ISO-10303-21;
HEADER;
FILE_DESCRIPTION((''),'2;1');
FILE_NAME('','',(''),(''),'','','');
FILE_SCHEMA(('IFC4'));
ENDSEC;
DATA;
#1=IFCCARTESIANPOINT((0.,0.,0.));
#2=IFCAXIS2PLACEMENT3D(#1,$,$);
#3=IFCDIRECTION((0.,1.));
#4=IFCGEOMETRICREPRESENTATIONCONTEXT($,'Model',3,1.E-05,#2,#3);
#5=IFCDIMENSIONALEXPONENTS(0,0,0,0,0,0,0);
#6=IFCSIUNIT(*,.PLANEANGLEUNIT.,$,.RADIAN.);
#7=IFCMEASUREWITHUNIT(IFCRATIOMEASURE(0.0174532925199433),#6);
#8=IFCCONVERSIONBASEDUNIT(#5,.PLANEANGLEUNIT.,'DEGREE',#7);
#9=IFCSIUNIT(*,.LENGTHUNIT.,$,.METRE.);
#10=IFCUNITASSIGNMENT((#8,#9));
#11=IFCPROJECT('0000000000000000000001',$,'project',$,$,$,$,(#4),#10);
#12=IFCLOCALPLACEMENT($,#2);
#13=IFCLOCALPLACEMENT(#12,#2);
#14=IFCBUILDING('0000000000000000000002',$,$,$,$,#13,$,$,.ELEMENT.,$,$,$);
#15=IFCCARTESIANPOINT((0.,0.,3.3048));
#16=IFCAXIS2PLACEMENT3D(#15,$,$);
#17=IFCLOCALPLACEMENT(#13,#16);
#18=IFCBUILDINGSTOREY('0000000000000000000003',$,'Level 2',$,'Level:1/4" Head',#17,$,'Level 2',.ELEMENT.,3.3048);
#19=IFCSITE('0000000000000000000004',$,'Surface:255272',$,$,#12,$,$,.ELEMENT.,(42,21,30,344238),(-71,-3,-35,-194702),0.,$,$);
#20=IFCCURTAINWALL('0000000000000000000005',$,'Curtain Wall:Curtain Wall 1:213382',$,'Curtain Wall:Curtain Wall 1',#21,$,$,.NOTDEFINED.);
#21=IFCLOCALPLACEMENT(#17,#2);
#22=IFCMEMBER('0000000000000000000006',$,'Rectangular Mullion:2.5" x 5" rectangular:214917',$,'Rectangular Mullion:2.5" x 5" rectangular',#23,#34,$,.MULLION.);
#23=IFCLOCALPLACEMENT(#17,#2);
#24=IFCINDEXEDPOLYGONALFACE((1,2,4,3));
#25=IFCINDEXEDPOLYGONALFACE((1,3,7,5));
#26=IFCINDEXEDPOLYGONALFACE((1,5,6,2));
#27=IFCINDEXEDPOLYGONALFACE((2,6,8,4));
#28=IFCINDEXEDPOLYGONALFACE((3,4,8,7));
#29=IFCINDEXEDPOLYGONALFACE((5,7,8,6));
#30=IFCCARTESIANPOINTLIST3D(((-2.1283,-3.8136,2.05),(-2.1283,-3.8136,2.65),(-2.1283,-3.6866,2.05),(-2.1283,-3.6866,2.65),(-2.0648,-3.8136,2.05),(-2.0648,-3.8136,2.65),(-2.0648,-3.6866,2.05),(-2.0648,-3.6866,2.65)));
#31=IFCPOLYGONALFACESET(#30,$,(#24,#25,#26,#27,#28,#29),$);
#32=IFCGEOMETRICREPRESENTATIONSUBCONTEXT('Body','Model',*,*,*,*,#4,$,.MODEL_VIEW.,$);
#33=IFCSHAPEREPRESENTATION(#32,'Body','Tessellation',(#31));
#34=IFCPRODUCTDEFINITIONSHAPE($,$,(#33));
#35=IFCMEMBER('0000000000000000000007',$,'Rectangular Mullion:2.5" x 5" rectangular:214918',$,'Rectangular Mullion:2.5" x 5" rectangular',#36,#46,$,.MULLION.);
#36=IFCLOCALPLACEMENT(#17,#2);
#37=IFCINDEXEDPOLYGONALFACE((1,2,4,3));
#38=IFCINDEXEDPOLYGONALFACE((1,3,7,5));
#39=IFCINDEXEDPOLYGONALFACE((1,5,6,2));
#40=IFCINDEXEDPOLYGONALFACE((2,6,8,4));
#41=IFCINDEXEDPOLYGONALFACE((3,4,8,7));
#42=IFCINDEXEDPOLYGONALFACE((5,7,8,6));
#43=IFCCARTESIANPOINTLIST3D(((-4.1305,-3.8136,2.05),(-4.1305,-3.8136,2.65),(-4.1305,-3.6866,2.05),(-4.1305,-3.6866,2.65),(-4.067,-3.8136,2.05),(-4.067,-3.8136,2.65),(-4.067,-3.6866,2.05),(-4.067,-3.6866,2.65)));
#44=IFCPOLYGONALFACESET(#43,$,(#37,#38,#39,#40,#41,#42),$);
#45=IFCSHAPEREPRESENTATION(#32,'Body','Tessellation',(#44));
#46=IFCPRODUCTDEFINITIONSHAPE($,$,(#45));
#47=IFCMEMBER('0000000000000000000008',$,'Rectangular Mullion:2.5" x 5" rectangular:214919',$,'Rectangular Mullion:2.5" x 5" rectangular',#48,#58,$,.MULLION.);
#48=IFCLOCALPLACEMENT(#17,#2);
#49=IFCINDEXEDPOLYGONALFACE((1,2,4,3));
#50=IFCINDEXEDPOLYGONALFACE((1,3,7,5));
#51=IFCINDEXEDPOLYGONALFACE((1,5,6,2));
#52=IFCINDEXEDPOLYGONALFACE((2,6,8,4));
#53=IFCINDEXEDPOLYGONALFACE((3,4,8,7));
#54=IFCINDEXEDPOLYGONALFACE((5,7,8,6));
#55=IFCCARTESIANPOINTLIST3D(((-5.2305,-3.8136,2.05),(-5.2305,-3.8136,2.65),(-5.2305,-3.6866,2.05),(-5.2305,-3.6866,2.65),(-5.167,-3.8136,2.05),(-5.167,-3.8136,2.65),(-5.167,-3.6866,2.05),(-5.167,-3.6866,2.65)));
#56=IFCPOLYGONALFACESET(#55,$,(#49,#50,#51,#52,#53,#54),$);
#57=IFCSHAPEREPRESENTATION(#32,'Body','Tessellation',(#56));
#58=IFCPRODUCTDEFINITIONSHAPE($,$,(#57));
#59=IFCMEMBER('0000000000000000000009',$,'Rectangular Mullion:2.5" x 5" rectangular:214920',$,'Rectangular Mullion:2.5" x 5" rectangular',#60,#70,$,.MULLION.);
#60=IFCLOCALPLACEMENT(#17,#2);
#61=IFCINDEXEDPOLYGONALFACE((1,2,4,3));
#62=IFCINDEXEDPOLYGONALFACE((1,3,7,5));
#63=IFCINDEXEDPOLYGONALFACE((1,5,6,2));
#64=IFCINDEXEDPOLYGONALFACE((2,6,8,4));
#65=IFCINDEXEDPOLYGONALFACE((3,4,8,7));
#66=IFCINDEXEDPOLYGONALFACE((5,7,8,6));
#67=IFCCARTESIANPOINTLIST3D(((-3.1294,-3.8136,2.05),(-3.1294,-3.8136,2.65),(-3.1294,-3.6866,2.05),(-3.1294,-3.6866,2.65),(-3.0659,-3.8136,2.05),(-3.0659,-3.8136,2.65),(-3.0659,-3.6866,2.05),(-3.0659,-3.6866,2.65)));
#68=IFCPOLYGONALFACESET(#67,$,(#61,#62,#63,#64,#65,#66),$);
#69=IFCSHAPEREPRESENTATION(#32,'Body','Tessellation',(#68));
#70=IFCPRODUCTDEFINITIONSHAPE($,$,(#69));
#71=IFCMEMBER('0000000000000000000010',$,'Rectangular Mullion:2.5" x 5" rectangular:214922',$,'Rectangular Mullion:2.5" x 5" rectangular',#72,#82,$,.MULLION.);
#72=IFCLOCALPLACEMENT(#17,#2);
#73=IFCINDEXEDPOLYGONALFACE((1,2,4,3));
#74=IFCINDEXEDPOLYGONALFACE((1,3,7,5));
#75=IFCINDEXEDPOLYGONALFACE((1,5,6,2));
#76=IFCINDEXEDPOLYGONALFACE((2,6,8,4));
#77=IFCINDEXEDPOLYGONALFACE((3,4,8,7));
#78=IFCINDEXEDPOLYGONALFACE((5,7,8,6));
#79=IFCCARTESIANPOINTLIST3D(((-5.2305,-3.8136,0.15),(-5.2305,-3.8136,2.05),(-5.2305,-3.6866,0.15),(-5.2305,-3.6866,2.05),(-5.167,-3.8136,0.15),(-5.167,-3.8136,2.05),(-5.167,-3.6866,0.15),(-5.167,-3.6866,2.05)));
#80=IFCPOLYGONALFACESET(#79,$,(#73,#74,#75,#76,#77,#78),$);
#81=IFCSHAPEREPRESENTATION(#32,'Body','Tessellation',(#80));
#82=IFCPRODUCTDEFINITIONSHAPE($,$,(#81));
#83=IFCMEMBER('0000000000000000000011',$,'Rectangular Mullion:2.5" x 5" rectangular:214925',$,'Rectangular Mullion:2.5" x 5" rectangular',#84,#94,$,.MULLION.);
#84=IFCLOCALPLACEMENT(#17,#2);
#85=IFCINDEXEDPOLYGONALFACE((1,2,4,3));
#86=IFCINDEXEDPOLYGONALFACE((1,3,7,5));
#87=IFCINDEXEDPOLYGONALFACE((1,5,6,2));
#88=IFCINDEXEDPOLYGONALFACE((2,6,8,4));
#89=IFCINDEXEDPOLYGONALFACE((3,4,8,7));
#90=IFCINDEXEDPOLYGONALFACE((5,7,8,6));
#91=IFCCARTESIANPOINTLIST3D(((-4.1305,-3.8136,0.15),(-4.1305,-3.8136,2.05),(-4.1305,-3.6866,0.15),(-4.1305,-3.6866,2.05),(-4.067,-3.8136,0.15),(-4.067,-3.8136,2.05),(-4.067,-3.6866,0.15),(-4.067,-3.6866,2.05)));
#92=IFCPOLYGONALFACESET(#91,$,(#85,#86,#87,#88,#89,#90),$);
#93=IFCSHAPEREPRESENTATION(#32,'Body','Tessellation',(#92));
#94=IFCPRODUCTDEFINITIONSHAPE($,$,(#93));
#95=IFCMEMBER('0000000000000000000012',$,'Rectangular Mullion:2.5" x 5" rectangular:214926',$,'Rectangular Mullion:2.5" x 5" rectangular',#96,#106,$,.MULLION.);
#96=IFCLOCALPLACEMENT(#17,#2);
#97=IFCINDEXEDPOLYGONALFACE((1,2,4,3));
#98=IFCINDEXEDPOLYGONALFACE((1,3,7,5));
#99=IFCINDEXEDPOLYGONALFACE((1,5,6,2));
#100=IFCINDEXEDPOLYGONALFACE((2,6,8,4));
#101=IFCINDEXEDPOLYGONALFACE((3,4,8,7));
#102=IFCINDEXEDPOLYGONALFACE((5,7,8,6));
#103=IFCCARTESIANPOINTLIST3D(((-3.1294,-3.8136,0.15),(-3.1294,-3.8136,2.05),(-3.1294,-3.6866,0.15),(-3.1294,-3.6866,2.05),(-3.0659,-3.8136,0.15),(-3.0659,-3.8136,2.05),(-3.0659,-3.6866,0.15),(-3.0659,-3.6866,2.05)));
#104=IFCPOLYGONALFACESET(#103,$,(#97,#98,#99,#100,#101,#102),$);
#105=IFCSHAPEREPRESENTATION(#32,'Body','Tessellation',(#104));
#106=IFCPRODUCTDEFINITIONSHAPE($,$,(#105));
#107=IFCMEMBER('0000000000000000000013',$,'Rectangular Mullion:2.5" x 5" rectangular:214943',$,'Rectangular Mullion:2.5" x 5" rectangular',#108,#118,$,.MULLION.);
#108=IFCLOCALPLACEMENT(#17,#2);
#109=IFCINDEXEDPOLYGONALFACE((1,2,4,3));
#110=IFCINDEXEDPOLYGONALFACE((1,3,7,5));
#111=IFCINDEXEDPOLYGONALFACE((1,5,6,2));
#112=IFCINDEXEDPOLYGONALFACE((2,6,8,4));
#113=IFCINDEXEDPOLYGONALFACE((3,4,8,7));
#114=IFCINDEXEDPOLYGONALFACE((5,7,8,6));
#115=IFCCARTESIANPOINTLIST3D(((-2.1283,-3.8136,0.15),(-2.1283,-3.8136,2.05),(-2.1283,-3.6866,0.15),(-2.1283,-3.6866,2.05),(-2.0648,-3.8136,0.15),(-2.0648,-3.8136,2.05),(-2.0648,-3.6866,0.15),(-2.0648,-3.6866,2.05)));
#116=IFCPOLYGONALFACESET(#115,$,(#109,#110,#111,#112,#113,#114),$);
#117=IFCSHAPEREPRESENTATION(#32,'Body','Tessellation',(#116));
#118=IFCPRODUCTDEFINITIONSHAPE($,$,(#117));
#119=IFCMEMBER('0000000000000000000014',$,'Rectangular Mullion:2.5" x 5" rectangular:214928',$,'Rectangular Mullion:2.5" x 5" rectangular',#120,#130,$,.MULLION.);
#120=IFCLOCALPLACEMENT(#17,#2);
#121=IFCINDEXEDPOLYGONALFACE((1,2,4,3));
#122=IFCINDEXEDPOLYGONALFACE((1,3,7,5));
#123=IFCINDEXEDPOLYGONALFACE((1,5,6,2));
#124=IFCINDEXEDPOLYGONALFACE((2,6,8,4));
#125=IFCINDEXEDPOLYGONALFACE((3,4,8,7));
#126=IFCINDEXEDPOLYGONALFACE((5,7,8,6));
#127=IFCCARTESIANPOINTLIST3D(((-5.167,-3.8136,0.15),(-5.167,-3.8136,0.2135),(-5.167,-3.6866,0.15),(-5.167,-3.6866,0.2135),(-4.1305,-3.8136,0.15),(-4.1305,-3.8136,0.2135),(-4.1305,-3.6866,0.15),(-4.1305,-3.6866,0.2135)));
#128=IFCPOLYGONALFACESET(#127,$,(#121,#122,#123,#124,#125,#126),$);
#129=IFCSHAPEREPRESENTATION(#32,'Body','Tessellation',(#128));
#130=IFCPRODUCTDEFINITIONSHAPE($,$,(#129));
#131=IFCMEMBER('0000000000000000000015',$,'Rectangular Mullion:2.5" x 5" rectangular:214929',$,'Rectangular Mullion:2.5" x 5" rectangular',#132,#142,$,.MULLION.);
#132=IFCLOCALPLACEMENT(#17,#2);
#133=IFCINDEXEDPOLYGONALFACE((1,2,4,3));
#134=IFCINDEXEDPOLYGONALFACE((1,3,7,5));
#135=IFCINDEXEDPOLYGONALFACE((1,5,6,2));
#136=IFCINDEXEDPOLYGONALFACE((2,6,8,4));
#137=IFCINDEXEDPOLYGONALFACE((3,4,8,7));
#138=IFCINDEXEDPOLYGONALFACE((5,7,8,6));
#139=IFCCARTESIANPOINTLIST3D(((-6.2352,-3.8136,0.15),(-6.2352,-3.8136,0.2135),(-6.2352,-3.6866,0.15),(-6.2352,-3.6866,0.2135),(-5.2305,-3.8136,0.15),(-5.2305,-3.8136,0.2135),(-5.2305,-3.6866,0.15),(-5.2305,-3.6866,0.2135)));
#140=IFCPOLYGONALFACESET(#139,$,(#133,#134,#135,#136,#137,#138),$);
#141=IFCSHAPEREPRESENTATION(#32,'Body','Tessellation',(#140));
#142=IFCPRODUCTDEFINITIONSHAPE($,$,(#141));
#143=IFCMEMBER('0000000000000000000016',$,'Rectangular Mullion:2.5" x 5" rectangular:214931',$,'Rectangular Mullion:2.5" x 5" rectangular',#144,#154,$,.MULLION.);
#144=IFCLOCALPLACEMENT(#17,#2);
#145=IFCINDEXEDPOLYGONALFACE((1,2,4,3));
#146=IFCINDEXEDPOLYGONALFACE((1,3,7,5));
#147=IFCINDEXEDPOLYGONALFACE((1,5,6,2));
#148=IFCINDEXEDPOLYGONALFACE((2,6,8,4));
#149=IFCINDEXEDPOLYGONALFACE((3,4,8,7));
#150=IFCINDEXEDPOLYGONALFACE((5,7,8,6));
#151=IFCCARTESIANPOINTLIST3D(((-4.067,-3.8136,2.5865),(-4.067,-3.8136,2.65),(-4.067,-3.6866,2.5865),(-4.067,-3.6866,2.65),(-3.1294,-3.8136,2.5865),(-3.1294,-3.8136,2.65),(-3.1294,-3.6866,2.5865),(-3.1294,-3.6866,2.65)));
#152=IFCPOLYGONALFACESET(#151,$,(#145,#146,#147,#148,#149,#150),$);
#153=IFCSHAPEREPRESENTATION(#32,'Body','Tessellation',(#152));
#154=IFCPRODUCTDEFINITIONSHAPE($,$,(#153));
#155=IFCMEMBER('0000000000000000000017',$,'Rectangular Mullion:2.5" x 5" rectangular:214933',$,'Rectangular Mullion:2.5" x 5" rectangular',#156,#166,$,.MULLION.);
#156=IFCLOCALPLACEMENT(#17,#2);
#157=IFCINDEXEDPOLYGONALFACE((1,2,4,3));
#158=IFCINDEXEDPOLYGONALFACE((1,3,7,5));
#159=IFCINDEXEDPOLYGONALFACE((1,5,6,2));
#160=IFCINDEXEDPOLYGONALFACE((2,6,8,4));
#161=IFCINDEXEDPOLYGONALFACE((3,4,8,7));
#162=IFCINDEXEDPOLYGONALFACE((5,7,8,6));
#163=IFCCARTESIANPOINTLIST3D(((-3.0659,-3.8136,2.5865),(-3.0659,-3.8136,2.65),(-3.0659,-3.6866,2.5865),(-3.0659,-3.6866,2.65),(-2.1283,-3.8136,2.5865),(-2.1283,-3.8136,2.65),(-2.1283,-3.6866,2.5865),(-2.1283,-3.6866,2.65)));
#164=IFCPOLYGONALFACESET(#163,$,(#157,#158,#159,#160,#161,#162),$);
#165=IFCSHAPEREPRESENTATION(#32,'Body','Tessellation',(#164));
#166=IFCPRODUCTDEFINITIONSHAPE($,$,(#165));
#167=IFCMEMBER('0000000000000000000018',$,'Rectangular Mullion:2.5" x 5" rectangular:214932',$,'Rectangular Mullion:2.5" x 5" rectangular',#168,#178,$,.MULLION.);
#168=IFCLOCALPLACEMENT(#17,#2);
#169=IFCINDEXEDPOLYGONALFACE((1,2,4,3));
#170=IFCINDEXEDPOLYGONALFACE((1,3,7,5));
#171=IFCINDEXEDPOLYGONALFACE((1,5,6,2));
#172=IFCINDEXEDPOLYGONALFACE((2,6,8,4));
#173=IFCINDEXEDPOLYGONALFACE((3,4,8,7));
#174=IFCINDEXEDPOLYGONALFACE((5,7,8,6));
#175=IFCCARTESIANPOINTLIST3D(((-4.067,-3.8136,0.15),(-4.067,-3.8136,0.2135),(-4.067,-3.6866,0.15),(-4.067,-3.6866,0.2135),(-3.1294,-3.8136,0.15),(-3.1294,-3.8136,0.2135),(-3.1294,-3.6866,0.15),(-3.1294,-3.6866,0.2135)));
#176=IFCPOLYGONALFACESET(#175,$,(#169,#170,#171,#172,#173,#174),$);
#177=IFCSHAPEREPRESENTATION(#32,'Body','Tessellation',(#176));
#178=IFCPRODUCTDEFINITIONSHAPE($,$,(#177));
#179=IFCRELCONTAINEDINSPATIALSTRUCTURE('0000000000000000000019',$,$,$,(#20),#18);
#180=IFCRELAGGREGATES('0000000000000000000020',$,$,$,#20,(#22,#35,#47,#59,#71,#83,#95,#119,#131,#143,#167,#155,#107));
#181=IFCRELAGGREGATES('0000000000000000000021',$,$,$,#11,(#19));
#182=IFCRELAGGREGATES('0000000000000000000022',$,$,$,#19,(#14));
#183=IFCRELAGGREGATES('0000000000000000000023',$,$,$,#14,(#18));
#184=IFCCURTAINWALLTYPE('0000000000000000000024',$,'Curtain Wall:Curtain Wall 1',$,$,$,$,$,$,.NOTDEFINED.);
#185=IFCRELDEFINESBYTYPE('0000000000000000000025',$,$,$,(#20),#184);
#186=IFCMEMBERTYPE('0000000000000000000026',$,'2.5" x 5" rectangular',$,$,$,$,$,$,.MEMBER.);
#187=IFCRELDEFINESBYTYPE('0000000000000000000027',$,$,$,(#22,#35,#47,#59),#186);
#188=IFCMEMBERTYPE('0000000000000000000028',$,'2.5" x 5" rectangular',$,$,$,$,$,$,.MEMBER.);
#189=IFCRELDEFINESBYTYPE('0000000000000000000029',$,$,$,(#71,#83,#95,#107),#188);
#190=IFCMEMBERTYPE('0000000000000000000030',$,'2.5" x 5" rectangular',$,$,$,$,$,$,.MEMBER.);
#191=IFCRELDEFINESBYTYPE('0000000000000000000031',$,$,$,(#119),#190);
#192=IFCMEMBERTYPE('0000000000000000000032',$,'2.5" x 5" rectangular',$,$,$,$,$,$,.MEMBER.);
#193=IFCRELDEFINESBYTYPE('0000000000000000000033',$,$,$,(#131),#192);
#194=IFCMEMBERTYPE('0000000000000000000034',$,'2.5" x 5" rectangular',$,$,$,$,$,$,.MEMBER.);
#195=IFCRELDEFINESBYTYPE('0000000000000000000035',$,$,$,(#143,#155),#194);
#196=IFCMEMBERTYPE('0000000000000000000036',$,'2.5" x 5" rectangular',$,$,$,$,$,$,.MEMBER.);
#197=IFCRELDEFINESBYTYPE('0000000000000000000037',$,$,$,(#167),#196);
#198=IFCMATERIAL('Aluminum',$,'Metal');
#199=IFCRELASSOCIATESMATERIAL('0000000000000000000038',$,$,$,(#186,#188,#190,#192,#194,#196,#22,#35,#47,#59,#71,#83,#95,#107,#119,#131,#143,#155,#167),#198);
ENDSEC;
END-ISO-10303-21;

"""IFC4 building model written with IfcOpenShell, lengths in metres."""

from ifc_helpers import new_model, entity, si_unit, converted_unit, direction, frame, origin, origin_2d_with_axis, place, context, subcontext, project, spatial, rectangle, extrude, source, transform, mapped, material, material_profile, profile_set, profile_usage, type_object, type_shapes, element, aggregate, save


model = new_model("IFC4")

# Units and contexts
model_context = context("Model", 3, precision=1e-05, world=origin(), true_north=direction((0.0, 1.0)))
body_context = subcontext(model_context, "Body", "Model", "MODEL_VIEW")
ifc_project = project(units=[converted_unit("PLANEANGLEUNIT", "DEGREE", entity("IfcRatioMeasure", 0.0174532925199433), si_unit("PLANEANGLEUNIT", "RADIAN"), dimensions=[0, 0, 0, 0, 0, 0, 0]), si_unit("LENGTHUNIT", "METRE")], contexts=[model_context])

# Site, building, storey
site_placement = place(None, origin())
site = spatial("IfcSite", under=ifc_project, at=site_placement, Name="Surface:255272", CompositionType="ELEMENT", RefLatitude=(42, 21, 30, 344238), RefLongitude=(-71, -3, -35, -194702), RefElevation=0.0)
building_placement = place(site_placement, origin())
building = spatial("IfcBuilding", under=site, at=building_placement, CompositionType="ELEMENT")
storey_placement = place(building_placement, frame((0.0, 0.0, 3.3048)))
storey = spatial("IfcBuildingStorey", under=building, at=storey_placement, Name="Level 2", ObjectType="Level:1/4\" Head", LongName="Level 2", CompositionType="ELEMENT", Elevation=3.3048)

# Curtain wall, members
curtain_wall_type = type_object("IfcCurtainWallType", Name="Curtain Wall:Curtain Wall 1", PredefinedType="NOTDEFINED")
curtain_wall_placement = place(storey_placement, frame((0.0, 0.0, -3.3048)))
curtain_wall = element("IfcCurtainWall", 1, at=curtain_wall_placement, inside=storey, type_object=curtain_wall_type, Name="Curtain Wall:Curtain Wall 1:213382", ObjectType="Curtain Wall:Curtain Wall 1", PredefinedType="NOTDEFINED")
ifc_material_1 = material(Name="Aluminum", Category="Metal")
ifc_material_profile = material_profile(ifc_material_1, rectangle(XDim=0.127, YDim=0.0635, at=origin_2d_with_axis()), Name="2.5\" x 5\" rectangular")
ifc_profile_set = profile_set([ifc_material_profile], Name="2.5\" x 5\" rectangular")
ifc_profile_usage_1 = profile_usage(ifc_profile_set)
member_type_1 = type_object("IfcMemberType", Name="2.5\" x 5\" rectangular", PredefinedType="MEMBER", material=ifc_profile_set)
shared_shape_1 = source(origin(), body_context, "Body", "SweptSolid", [
    extrude(rectangle(XDim=0.127, YDim=0.0635, at=origin_2d_with_axis()), frame((0.0, 0.0, -0.6), z_axis=(0.0, 0.0, 1.0), x_axis=(0.0, -1.0, 0.0)), (0.0, 0.0, 1.0), 0.6),
])
type_shapes(member_type_1, [shared_shape_1])
member_1_placement = place(storey_placement, frame((-2.0966, -3.7501, 2.05), z_axis=(0.0, 0.0, -1.0), x_axis=(-1.0, 0.000007, 0.0)))
member_1 = element("IfcMember", 2, at=member_1_placement, type_object=member_type_1, material=ifc_profile_usage_1, Name="Rectangular Mullion:2.5\" x 5\" rectangular:214917", ObjectType="Rectangular Mullion:2.5\" x 5\" rectangular", PredefinedType="MULLION", context=body_context, shape_type="MappedRepresentation", body=[
    mapped(shared_shape_1, transform((0.0, 0.0, 0.0), scale=1.0)),
])
ifc_profile_usage_2 = profile_usage(ifc_profile_set)
member_2_placement = place(storey_placement, frame((-4.0987, -3.7501, 2.05), z_axis=(0.0, 0.0, -1.0), x_axis=(-1.0, 0.000007, 0.0)))
member_2 = element("IfcMember", 3, at=member_2_placement, type_object=member_type_1, material=ifc_profile_usage_2, Name="Rectangular Mullion:2.5\" x 5\" rectangular:214918", ObjectType="Rectangular Mullion:2.5\" x 5\" rectangular", PredefinedType="MULLION", context=body_context, shape_type="MappedRepresentation", body=[
    mapped(shared_shape_1, transform((0.0, 0.0, 0.0), scale=1.0)),
])
ifc_profile_usage_3 = profile_usage(ifc_profile_set)
member_3_placement = place(storey_placement, frame((-5.1987, -3.7501, 2.05), z_axis=(0.0, 0.0, -1.0), x_axis=(-1.0, 0.000007, 0.0)))
member_3 = element("IfcMember", 4, at=member_3_placement, type_object=member_type_1, material=ifc_profile_usage_3, Name="Rectangular Mullion:2.5\" x 5\" rectangular:214919", ObjectType="Rectangular Mullion:2.5\" x 5\" rectangular", PredefinedType="MULLION", context=body_context, shape_type="MappedRepresentation", body=[
    mapped(shared_shape_1, transform((0.0, 0.0, 0.0), scale=1.0)),
])
ifc_profile_usage_4 = profile_usage(ifc_profile_set)
member_4_placement = place(storey_placement, frame((-3.0977, -3.7501, 2.05), z_axis=(0.0, 0.0, -1.0), x_axis=(-1.0, 0.000007, 0.0)))
member_4 = element("IfcMember", 5, at=member_4_placement, type_object=member_type_1, material=ifc_profile_usage_4, Name="Rectangular Mullion:2.5\" x 5\" rectangular:214920", ObjectType="Rectangular Mullion:2.5\" x 5\" rectangular", PredefinedType="MULLION", context=body_context, shape_type="MappedRepresentation", body=[
    mapped(shared_shape_1, transform((0.0, 0.0, 0.0), scale=1.0)),
])
ifc_profile_usage_5 = profile_usage(ifc_profile_set)
member_type_2 = type_object("IfcMemberType", Name="2.5\" x 5\" rectangular", PredefinedType="MEMBER", material=ifc_profile_set)
shared_shape_2 = source(origin(), body_context, "Body", "SweptSolid", [
    extrude(rectangle(XDim=0.127, YDim=0.0635, at=origin_2d_with_axis()), frame((0.0, 0.0, -1.9), z_axis=(0.0, 0.0, 1.0), x_axis=(0.0, -1.0, 0.0)), (0.0, 0.0, 1.0), 1.9),
])
type_shapes(member_type_2, [shared_shape_2])
member_5_placement = place(storey_placement, frame((-5.1987, -3.7501, 0.15), z_axis=(0.0, 0.0, -1.0), x_axis=(-1.0, 0.000007, 0.0)))
member_5 = element("IfcMember", 6, at=member_5_placement, type_object=member_type_2, material=ifc_profile_usage_5, Name="Rectangular Mullion:2.5\" x 5\" rectangular:214922", ObjectType="Rectangular Mullion:2.5\" x 5\" rectangular", PredefinedType="MULLION", context=body_context, shape_type="MappedRepresentation", body=[
    mapped(shared_shape_2, transform((0.0, 0.0, 0.0), scale=1.0)),
])
ifc_profile_usage_6 = profile_usage(ifc_profile_set)
member_6_placement = place(storey_placement, frame((-4.0987, -3.7501, 0.15), z_axis=(0.0, 0.0, -1.0), x_axis=(-1.0, 0.000007, 0.0)))
member_6 = element("IfcMember", 7, at=member_6_placement, type_object=member_type_2, material=ifc_profile_usage_6, Name="Rectangular Mullion:2.5\" x 5\" rectangular:214925", ObjectType="Rectangular Mullion:2.5\" x 5\" rectangular", PredefinedType="MULLION", context=body_context, shape_type="MappedRepresentation", body=[
    mapped(shared_shape_2, transform((0.0, 0.0, 0.0), scale=1.0)),
])
ifc_profile_usage_7 = profile_usage(ifc_profile_set)
member_7_placement = place(storey_placement, frame((-3.0977, -3.7501, 0.15), z_axis=(0.0, 0.0, -1.0), x_axis=(-1.0, 0.000007, 0.0)))
member_7 = element("IfcMember", 8, at=member_7_placement, type_object=member_type_2, material=ifc_profile_usage_7, Name="Rectangular Mullion:2.5\" x 5\" rectangular:214926", ObjectType="Rectangular Mullion:2.5\" x 5\" rectangular", PredefinedType="MULLION", context=body_context, shape_type="MappedRepresentation", body=[
    mapped(shared_shape_2, transform((0.0, 0.0, 0.0), scale=1.0)),
])
ifc_profile_usage_8 = profile_usage(ifc_profile_set)
member_8_placement = place(storey_placement, frame((-2.0966, -3.7501, 0.15), z_axis=(0.0, 0.0, -1.0), x_axis=(-1.0, 0.000007, 0.0)))
member_8 = element("IfcMember", 9, at=member_8_placement, type_object=member_type_2, material=ifc_profile_usage_8, Name="Rectangular Mullion:2.5\" x 5\" rectangular:214943", ObjectType="Rectangular Mullion:2.5\" x 5\" rectangular", PredefinedType="MULLION", context=body_context, shape_type="MappedRepresentation", body=[
    mapped(shared_shape_2, transform((0.0, 0.0, 0.0), scale=1.0)),
])
ifc_profile_usage_9 = profile_usage(ifc_profile_set)
member_type_3 = type_object("IfcMemberType", Name="2.5\" x 5\" rectangular", PredefinedType="MEMBER", material=ifc_profile_set)
shared_shape_3 = source(origin(), body_context, "Body", "SweptSolid", [
    extrude(rectangle(XDim=0.127, YDim=0.0635, at=origin_2d_with_axis()), frame((-0.0318, 0.0, -1.0365), z_axis=(0.0, 0.0, 1.0), x_axis=(0.0, -1.0, 0.0)), (0.0, 0.0, 1.0), 1.0365),
])
type_shapes(member_type_3, [shared_shape_3])
member_9_placement = place(storey_placement, frame((-4.1305, -3.7501, 0.15), z_axis=(1.0, -0.000007, 0.0), x_axis=(0.0, 0.0, -1.0)))
member_9 = element("IfcMember", 10, at=member_9_placement, type_object=member_type_3, material=ifc_profile_usage_9, Name="Rectangular Mullion:2.5\" x 5\" rectangular:214928", ObjectType="Rectangular Mullion:2.5\" x 5\" rectangular", PredefinedType="MULLION", context=body_context, shape_type="MappedRepresentation", body=[
    mapped(shared_shape_3, transform((0.0, 0.0, 0.0), scale=1.0)),
])
ifc_profile_usage_10 = profile_usage(ifc_profile_set)
member_type_4 = type_object("IfcMemberType", Name="2.5\" x 5\" rectangular", PredefinedType="MEMBER", material=ifc_profile_set)
shared_shape_4 = source(origin(), body_context, "Body", "SweptSolid", [
    extrude(rectangle(XDim=0.127, YDim=0.0635, at=origin_2d_with_axis()), frame((-0.0318, 0.0, -1.0048), z_axis=(0.0, 0.0, 1.0), x_axis=(0.0, -1.0, 0.0)), (0.0, 0.0, 1.0), 1.0048),
])
type_shapes(member_type_4, [shared_shape_4])
member_10_placement = place(storey_placement, frame((-5.2305, -3.7501, 0.15), z_axis=(1.0, -0.000007, 0.0), x_axis=(0.0, 0.0, -1.0)))
member_10 = element("IfcMember", 11, at=member_10_placement, type_object=member_type_4, material=ifc_profile_usage_10, Name="Rectangular Mullion:2.5\" x 5\" rectangular:214929", ObjectType="Rectangular Mullion:2.5\" x 5\" rectangular", PredefinedType="MULLION", context=body_context, shape_type="MappedRepresentation", body=[
    mapped(shared_shape_4, transform((0.0, 0.0, 0.0), scale=1.0)),
])
ifc_profile_usage_11 = profile_usage(ifc_profile_set)
member_type_5 = type_object("IfcMemberType", Name="2.5\" x 5\" rectangular", PredefinedType="MEMBER", material=ifc_profile_set)
shared_shape_5 = source(origin(), body_context, "Body", "SweptSolid", [
    extrude(rectangle(XDim=0.127, YDim=0.0635, at=origin_2d_with_axis()), frame((-0.0318, 0.0, -0.9376), z_axis=(0.0, 0.0, 1.0), x_axis=(0.0, -1.0, 0.0)), (0.0, 0.0, 1.0), 0.9376),
])
type_shapes(member_type_5, [shared_shape_5])
member_11_placement = place(storey_placement, frame((-4.067, -3.7501, 2.65), z_axis=(-1.0, 0.000007, 0.0), x_axis=(0.0, 0.0, 1.0)))
member_11 = element("IfcMember", 12, at=member_11_placement, type_object=member_type_5, material=ifc_profile_usage_11, Name="Rectangular Mullion:2.5\" x 5\" rectangular:214931", ObjectType="Rectangular Mullion:2.5\" x 5\" rectangular", PredefinedType="MULLION", context=body_context, shape_type="MappedRepresentation", body=[
    mapped(shared_shape_5, transform((0.0, 0.0, 0.0), scale=1.0)),
])
ifc_profile_usage_12 = profile_usage(ifc_profile_set)
member_12_placement = place(storey_placement, frame((-3.0659, -3.7501, 2.65), z_axis=(-1.0, 0.000007, 0.0), x_axis=(0.0, 0.0, 1.0)))
member_12 = element("IfcMember", 13, at=member_12_placement, type_object=member_type_5, material=ifc_profile_usage_12, Name="Rectangular Mullion:2.5\" x 5\" rectangular:214933", ObjectType="Rectangular Mullion:2.5\" x 5\" rectangular", PredefinedType="MULLION", context=body_context, shape_type="MappedRepresentation", body=[
    mapped(shared_shape_5, transform((0.0, 0.0, 0.0), scale=1.0)),
])
ifc_profile_usage_13 = profile_usage(ifc_profile_set)
member_type_6 = type_object("IfcMemberType", Name="2.5\" x 5\" rectangular", PredefinedType="MEMBER", material=ifc_profile_set)
shared_shape_6 = source(origin(), body_context, "Body", "SweptSolid", [
    extrude(rectangle(XDim=0.127, YDim=0.0635, at=origin_2d_with_axis()), frame((-0.0318, 0.0, -0.9376), z_axis=(0.0, 0.0, 1.0), x_axis=(0.0, -1.0, 0.0)), (0.0, 0.0, 1.0), 0.9376),
])
type_shapes(member_type_6, [shared_shape_6])
member_13_placement = place(storey_placement, frame((-3.1294, -3.7501, 0.15), z_axis=(1.0, -0.000007, 0.0), x_axis=(0.0, 0.0, -1.0)))
member_13 = element("IfcMember", 14, at=member_13_placement, type_object=member_type_6, material=ifc_profile_usage_13, Name="Rectangular Mullion:2.5\" x 5\" rectangular:214932", ObjectType="Rectangular Mullion:2.5\" x 5\" rectangular", PredefinedType="MULLION", context=body_context, shape_type="MappedRepresentation", body=[
    mapped(shared_shape_6, transform((0.0, 0.0, 0.0), scale=1.0)),
])
aggregate(curtain_wall, [member_1, member_2, member_3, member_4, member_5, member_6, member_7, member_9, member_10, member_11, member_13, member_12, member_8])

save(model, "model.ifc")
